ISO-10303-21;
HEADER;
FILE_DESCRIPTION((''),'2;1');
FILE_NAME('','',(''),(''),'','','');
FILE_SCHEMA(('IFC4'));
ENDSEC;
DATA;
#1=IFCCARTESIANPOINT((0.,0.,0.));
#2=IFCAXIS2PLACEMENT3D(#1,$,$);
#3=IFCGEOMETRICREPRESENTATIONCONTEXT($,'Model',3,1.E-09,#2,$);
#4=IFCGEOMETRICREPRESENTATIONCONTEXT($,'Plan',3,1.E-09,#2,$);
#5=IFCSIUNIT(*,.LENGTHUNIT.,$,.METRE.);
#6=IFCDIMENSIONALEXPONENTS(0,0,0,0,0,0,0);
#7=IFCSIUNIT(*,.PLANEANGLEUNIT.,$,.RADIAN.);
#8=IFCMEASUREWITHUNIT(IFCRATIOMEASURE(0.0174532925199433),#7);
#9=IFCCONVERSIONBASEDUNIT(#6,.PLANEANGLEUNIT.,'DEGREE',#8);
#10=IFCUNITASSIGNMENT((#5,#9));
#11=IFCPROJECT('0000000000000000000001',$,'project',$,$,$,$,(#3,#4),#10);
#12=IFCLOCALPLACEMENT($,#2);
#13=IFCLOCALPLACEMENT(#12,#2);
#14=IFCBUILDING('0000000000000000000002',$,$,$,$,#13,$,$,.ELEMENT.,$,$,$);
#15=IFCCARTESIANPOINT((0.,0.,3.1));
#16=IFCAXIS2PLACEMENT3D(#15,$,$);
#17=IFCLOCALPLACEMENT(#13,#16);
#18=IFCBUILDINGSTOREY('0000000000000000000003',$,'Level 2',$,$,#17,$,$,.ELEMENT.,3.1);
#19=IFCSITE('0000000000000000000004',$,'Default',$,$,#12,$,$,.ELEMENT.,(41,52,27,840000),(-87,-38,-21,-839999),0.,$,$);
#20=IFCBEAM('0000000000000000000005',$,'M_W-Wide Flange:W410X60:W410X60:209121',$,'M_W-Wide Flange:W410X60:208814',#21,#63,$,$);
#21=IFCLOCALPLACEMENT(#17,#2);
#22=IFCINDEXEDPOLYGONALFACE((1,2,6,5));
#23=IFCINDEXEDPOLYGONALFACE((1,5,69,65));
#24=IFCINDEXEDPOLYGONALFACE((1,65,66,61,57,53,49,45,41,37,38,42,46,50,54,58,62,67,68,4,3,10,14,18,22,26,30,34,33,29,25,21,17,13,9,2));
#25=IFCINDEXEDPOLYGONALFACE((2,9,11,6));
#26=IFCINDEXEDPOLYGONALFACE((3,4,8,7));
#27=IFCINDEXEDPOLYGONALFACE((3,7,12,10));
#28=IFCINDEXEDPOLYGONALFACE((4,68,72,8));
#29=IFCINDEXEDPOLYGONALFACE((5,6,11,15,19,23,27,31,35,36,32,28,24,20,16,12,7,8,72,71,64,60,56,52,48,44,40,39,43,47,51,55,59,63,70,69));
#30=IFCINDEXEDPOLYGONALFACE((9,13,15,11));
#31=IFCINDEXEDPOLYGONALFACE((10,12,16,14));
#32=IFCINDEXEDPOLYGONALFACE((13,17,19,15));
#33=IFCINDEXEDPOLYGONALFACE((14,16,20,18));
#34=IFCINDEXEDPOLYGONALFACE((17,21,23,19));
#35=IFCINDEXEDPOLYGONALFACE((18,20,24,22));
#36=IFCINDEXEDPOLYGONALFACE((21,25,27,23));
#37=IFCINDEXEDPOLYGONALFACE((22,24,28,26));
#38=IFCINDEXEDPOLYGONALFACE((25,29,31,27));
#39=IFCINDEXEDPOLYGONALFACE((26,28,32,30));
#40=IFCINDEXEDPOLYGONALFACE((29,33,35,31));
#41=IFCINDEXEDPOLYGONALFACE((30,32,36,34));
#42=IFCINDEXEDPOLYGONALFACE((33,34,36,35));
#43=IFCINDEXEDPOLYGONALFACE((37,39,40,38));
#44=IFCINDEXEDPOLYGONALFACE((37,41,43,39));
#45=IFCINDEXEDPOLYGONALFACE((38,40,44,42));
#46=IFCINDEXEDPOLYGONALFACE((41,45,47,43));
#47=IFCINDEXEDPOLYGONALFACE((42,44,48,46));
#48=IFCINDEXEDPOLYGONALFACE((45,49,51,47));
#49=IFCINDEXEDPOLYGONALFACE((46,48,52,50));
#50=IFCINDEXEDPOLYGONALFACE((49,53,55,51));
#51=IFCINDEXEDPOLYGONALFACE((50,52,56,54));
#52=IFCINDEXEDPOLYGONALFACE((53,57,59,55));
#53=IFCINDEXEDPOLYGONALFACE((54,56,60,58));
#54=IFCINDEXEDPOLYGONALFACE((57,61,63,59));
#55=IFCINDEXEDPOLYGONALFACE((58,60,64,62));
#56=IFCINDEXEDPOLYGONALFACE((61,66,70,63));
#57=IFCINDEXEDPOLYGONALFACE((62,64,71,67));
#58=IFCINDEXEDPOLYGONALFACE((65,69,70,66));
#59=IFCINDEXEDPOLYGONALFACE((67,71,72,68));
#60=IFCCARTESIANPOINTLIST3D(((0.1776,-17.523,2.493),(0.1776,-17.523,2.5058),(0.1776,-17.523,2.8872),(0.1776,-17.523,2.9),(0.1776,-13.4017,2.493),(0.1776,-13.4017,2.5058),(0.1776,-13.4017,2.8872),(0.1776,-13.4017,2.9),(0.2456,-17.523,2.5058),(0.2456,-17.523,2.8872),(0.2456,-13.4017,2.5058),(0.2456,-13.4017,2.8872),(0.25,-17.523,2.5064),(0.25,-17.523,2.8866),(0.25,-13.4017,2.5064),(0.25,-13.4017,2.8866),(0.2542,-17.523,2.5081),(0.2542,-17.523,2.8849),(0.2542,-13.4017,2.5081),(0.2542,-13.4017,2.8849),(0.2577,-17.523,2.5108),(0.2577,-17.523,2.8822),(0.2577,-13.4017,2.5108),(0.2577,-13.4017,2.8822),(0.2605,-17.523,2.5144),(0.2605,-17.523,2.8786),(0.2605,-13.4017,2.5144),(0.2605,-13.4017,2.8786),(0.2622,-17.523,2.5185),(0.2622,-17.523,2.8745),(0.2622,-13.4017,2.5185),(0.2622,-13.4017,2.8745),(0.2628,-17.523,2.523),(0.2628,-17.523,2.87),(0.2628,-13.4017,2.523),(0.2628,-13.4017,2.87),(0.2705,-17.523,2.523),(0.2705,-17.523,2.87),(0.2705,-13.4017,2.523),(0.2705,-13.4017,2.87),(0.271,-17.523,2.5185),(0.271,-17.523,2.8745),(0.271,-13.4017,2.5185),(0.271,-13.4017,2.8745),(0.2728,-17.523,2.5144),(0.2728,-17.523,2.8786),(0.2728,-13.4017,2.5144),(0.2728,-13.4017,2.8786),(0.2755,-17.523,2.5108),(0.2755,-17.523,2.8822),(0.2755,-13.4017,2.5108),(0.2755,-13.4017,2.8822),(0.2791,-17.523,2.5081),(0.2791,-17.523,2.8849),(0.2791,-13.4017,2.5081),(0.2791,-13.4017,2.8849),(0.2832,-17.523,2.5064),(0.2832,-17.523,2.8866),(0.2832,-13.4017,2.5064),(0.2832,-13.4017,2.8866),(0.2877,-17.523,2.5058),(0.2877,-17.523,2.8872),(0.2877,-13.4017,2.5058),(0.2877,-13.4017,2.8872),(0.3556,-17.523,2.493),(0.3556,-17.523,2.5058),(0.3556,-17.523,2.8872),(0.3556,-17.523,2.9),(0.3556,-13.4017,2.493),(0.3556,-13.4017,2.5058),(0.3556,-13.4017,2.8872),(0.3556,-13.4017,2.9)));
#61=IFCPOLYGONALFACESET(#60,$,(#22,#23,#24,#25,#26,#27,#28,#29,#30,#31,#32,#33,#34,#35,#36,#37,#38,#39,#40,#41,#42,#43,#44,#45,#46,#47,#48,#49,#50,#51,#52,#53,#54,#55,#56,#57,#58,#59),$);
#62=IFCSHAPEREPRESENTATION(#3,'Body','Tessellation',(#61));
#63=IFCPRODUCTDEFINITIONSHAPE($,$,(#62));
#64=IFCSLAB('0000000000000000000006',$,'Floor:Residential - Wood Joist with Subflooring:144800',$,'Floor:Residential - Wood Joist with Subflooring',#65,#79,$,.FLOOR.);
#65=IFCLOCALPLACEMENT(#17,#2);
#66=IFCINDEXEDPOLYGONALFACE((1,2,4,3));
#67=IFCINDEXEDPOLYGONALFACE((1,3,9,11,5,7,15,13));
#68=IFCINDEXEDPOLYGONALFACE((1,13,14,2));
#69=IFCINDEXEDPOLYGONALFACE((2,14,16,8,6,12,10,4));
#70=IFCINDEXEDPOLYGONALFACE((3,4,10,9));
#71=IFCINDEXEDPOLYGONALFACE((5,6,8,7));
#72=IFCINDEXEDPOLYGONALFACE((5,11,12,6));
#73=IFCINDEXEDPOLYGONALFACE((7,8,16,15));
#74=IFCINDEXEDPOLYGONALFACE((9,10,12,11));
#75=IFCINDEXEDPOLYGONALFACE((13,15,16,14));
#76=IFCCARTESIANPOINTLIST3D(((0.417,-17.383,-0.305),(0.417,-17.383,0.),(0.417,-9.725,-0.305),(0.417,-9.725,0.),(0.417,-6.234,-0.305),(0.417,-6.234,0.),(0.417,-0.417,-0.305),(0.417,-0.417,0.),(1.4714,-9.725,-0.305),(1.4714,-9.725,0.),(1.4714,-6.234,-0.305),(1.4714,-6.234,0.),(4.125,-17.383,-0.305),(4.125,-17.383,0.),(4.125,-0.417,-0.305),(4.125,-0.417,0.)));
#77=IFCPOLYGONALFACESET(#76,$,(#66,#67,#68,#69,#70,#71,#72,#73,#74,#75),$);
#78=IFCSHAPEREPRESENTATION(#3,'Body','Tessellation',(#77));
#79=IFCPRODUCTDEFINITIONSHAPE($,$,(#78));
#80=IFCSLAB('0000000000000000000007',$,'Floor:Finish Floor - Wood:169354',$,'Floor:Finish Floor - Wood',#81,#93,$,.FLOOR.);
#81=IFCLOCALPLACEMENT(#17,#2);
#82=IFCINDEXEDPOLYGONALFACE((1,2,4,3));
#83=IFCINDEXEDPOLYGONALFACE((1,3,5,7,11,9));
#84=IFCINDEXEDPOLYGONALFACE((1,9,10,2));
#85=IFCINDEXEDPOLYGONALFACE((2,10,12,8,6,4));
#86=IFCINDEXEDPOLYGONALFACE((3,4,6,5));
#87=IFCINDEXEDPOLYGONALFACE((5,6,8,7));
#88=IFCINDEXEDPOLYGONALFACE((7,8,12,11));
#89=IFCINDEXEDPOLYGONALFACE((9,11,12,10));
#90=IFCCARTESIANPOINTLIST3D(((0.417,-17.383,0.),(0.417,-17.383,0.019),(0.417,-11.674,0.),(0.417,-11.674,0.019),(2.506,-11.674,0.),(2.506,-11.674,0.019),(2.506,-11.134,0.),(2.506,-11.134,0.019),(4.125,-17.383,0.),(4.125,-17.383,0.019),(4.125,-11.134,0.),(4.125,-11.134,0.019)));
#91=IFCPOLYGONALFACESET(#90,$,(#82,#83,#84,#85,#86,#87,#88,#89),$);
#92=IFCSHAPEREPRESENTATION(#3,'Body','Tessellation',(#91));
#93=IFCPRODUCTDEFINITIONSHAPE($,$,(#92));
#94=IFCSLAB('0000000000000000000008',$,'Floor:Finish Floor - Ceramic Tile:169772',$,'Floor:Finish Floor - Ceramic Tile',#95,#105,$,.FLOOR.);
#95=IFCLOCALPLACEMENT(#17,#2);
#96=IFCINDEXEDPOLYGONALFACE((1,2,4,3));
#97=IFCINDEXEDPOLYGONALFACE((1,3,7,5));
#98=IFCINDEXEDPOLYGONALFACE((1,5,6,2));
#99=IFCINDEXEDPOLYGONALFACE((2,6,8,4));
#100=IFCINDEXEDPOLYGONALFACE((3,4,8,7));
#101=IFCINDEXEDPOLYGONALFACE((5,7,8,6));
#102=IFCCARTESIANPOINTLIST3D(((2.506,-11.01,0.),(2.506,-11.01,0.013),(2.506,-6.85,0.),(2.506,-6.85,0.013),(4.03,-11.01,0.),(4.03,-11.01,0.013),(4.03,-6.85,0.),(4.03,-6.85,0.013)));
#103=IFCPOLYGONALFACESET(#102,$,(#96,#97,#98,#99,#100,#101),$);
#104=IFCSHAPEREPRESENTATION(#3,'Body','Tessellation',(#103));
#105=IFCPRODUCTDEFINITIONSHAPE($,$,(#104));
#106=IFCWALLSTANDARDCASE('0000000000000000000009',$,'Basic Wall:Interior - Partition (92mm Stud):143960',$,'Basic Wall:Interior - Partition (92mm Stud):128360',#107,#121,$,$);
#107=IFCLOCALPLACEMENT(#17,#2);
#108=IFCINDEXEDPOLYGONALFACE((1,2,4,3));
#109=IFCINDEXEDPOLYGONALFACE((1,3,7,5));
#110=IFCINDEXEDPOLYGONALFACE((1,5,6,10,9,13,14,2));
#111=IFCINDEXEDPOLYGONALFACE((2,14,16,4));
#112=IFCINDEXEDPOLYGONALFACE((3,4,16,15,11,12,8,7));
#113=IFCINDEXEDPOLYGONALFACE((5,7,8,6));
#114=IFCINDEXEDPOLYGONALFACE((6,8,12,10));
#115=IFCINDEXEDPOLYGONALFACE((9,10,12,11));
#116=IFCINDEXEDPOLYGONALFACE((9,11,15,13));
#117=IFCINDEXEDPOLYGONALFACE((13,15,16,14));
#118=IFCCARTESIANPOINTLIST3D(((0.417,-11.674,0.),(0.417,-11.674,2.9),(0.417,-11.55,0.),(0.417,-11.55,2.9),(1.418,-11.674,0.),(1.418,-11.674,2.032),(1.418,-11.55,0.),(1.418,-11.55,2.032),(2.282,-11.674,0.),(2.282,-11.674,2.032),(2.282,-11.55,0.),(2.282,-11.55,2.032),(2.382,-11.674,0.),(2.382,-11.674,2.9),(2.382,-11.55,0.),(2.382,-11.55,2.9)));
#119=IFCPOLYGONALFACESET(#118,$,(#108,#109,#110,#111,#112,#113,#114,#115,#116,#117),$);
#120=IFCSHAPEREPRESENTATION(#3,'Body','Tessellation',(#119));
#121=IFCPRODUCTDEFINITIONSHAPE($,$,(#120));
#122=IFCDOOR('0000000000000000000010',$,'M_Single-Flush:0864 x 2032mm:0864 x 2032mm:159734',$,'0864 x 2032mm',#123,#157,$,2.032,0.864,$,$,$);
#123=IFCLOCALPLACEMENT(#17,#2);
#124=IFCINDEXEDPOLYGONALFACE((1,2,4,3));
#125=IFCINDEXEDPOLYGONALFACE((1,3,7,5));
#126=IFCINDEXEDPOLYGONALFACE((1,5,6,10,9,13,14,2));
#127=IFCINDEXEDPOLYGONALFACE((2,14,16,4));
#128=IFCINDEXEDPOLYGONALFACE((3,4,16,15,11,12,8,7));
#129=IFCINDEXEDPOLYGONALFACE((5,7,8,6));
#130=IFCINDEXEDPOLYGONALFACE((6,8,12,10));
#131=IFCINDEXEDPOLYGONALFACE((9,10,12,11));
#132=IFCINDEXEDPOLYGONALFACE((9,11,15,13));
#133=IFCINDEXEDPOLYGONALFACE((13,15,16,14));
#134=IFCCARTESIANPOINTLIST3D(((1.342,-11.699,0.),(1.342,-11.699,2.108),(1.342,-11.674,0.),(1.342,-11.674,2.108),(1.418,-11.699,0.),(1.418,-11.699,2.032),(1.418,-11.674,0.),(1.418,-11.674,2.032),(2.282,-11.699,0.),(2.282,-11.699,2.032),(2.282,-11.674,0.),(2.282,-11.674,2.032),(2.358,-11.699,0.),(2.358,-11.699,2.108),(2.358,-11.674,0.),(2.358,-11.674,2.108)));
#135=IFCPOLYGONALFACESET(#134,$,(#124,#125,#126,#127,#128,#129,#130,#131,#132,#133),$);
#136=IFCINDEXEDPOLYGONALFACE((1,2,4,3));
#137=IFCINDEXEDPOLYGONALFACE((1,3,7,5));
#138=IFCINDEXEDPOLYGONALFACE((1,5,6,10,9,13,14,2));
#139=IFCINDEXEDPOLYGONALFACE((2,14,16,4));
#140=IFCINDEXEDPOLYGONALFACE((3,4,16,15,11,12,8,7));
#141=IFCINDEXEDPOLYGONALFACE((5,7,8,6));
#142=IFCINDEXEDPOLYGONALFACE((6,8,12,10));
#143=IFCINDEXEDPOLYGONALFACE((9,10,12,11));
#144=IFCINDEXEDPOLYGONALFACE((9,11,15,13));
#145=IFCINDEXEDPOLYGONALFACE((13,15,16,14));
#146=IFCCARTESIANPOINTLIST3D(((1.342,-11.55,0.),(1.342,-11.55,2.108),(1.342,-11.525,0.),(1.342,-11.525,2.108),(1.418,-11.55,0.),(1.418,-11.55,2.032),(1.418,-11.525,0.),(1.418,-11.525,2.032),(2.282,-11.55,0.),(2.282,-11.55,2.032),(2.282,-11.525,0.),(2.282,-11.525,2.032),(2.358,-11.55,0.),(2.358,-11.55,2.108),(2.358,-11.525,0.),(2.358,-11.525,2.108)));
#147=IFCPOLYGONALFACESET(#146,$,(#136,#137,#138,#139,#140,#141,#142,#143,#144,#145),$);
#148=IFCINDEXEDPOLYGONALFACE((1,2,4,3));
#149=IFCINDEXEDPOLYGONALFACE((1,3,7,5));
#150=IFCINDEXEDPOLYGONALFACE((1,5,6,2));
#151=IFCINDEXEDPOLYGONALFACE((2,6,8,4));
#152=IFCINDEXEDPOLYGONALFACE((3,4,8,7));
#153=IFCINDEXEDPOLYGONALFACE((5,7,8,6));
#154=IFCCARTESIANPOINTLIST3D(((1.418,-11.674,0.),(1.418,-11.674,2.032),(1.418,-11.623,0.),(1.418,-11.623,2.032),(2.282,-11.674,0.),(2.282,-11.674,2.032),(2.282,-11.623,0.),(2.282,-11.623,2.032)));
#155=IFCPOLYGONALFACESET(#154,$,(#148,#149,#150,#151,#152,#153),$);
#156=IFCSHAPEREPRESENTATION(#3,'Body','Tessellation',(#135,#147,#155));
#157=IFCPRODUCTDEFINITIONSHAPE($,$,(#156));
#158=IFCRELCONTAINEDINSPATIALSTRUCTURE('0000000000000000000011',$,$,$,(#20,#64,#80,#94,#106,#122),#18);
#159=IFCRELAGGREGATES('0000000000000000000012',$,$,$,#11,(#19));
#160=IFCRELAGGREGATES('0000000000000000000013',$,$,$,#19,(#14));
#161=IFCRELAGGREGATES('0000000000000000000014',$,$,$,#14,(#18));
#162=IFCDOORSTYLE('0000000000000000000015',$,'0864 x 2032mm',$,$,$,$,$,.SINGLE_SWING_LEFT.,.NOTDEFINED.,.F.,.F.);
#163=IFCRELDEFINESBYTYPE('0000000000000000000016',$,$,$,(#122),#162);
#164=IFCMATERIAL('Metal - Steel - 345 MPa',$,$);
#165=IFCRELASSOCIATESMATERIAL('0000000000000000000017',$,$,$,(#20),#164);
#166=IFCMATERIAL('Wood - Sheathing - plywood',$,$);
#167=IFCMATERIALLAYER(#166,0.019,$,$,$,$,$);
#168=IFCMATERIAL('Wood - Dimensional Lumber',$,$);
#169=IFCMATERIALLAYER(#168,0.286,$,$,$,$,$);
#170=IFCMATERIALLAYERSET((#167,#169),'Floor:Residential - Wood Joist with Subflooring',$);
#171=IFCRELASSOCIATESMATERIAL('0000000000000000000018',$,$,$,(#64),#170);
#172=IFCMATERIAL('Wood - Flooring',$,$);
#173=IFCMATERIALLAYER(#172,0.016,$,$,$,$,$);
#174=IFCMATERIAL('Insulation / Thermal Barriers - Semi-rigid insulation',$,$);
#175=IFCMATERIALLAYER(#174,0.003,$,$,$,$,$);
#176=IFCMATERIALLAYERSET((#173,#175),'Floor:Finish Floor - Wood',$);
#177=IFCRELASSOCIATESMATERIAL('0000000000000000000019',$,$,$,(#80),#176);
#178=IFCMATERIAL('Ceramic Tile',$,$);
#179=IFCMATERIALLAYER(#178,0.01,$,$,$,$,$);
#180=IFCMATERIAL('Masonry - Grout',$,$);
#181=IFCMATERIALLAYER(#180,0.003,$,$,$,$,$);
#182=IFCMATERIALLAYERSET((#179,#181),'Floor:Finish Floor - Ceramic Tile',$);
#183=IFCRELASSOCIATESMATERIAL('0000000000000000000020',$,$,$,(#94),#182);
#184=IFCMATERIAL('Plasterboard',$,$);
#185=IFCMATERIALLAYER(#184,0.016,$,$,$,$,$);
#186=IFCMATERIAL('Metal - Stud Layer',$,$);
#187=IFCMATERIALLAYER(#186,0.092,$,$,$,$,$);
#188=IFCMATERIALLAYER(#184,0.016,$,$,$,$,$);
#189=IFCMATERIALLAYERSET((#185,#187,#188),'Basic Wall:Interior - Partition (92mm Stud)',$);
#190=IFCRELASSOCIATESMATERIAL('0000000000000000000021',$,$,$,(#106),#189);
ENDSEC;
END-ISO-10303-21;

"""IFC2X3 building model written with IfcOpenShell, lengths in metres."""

from ifc_helpers import new_model, entity, si_unit, converted_unit, frame, frame_2d, origin, origin_2d_with_axis, place, context, project, spatial, polyline, circle_curve, parameter, trimmed, segment, composite_curve, rectangle, outline, extrude, source, transform, mapped, material, layer, layer_set, layer_usage, type_object, type_shapes, element, fill, save


model = new_model("IFC2X3")

# Units and contexts
model_context = context("Model", 3, precision=1e-09, world=origin())
plan_context = context("Plan", 3, precision=1e-09, world=origin())
ifc_project = project(units=[si_unit("LENGTHUNIT", "METRE"), converted_unit("PLANEANGLEUNIT", "DEGREE", entity("IfcRatioMeasure", 0.0174532925199433), si_unit("PLANEANGLEUNIT", "RADIAN"), dimensions=[0, 0, 0, 0, 0, 0, 0])], contexts=[model_context, plan_context])

# Site, building, storey
site_placement = place(None, origin())
site = spatial("IfcSite", under=ifc_project, at=site_placement, Name="Default", CompositionType="ELEMENT", RefLatitude=(41, 52, 27, 840000), RefLongitude=(-87, -38, -21, -839999), RefElevation=0.0)
building_placement = place(site_placement, origin())
building = spatial("IfcBuilding", under=site, at=building_placement, CompositionType="ELEMENT")
storey_placement = place(building_placement, frame((0.0, 0.0, 3.1)))
storey = spatial("IfcBuildingStorey", under=building, at=storey_placement, Name="Level 2", CompositionType="ELEMENT", Elevation=3.1)

# Beam
ifc_material_1 = material(Name="Metal - Steel - 345 MPa")
beam_placement = place(storey_placement, frame((0.2666, -13.4017, 2.9), z_axis=(0.0, 0.0, 1.0), x_axis=(-1.0, 0.0, 0.0)))
element("IfcBeam", 1, at=beam_placement, inside=storey, material=ifc_material_1, Name="M_W-Wide Flange:W410X60:W410X60:209121", ObjectType="M_W-Wide Flange:W410X60:208814", context=model_context, shape_type="SweptSolid", body=[
    extrude(outline(composite_curve([segment(polyline([(0.1907, -0.089), (0.2035, -0.089)]), True, "CONTINUOUS"), segment(polyline([(0.2035, -0.089), (0.2035, 0.089)]), True, "CONTINUOUS"), segment(polyline([(0.2035, 0.089), (0.1907, 0.089)]), True, "CONTINUOUS"), segment(polyline([(0.1907, 0.089), (0.1907, 0.021)]), True, "CONTINUOUS"), segment(trimmed(circle_curve(frame_2d((0.1735, 0.021), x_axis=(1.0, 0.0)), 0.0172), [parameter(270.0)], [parameter(360.0)], True, "PARAMETER"), False, "CONTINUOUS"), segment(polyline([(0.1735, 0.0038), (-0.1735, 0.0038)]), True, "CONTINUOUS"), segment(trimmed(circle_curve(frame_2d((-0.1735, 0.021), x_axis=(0.0, -1.0)), 0.0172), [parameter(270.0)], [parameter(360.0)], True, "PARAMETER"), False, "CONTINUOUS"), segment(polyline([(-0.1907, 0.021), (-0.1907, 0.089)]), True, "CONTINUOUS"), segment(polyline([(-0.1907, 0.089), (-0.2035, 0.089)]), True, "CONTINUOUS"), segment(polyline([(-0.2035, 0.089), (-0.2035, -0.089)]), True, "CONTINUOUS"), segment(polyline([(-0.2035, -0.089), (-0.1907, -0.089)]), True, "CONTINUOUS"), segment(polyline([(-0.1907, -0.089), (-0.1907, -0.0211)]), True, "CONTINUOUS"), segment(trimmed(circle_curve(frame_2d((-0.1735, -0.0211), x_axis=(-1.0, 0.0)), 0.0172), [parameter(270.0)], [parameter(0.0)], True, "PARAMETER"), False, "CONTINUOUS"), segment(polyline([(-0.1735, -0.0039), (0.1735, -0.0039)]), True, "CONTINUOUS"), segment(trimmed(circle_curve(frame_2d((0.1735, -0.0211), x_axis=(0.0, 1.0)), 0.0172), [parameter(270.0)], [parameter(0.0)], True, "PARAMETER"), False, "CONTINUOUS"), segment(polyline([(0.1907, -0.0211), (0.1907, -0.089)]), True, "CONTINUOUS")], self_intersect=False)), frame((0.0, 4.1213, -0.2035), z_axis=(0.0, -1.0, 0.0), x_axis=(0.0, 0.0, -1.0)), (0.0, 0.0, 1.0), 4.1213),
])

# Slabs
ifc_material_2 = material(Name="Wood - Sheathing - plywood")
ifc_layer_1 = layer(ifc_material_2, 0.019)
ifc_material_3 = material(Name="Wood - Dimensional Lumber")
ifc_layer_2 = layer(ifc_material_3, 0.286)
ifc_layer_set_1 = layer_set([ifc_layer_1, ifc_layer_2], Name="Floor:Residential - Wood Joist with Subflooring")
ifc_layer_usage_1 = layer_usage(ifc_layer_set_1, "AXIS3", "POSITIVE", 0.0)
slab_1_placement = place(storey_placement, frame((0.417, -17.383, -0.305)))
element("IfcSlab", 2, at=slab_1_placement, inside=storey, material=ifc_layer_usage_1, Name="Floor:Residential - Wood Joist with Subflooring:144800", ObjectType="Floor:Residential - Wood Joist with Subflooring", PredefinedType="FLOOR", context=model_context, shape_type="SweptSolid", body=[
    extrude(outline(polyline([(-1.854, 8.483), (-1.854, -8.483), (1.854, -8.483), (1.854, -0.825), (0.7996, -0.825), (0.7996, 2.666), (1.854, 2.666), (1.854, 8.483), (-1.854, 8.483)])), frame((1.854, 8.483, 0.305), z_axis=(0.0, 0.0, -1.0), x_axis=(-1.0, 0.0, 0.0)), (0.0, 0.0, 1.0), 0.305),
])
ifc_material_4 = material(Name="Wood - Flooring")
ifc_layer_3 = layer(ifc_material_4, 0.016)
ifc_material_5 = material(Name="Insulation / Thermal Barriers - Semi-rigid insulation")
ifc_layer_4 = layer(ifc_material_5, 0.003)
ifc_layer_set_2 = layer_set([ifc_layer_3, ifc_layer_4], Name="Floor:Finish Floor - Wood")
ifc_layer_usage_2 = layer_usage(ifc_layer_set_2, "AXIS3", "POSITIVE", 0.0)
slab_2_placement = place(storey_placement, frame((0.417, -17.383, 0.0)))
element("IfcSlab", 3, at=slab_2_placement, inside=storey, material=ifc_layer_usage_2, Name="Floor:Finish Floor - Wood:169354", ObjectType="Floor:Finish Floor - Wood", PredefinedType="FLOOR", context=model_context, shape_type="SweptSolid", body=[
    extrude(outline(polyline([(-1.854, -3.1245), (1.854, -3.1245), (1.854, 2.5845), (-0.235, 2.5845), (-0.235, 3.1245), (-1.854, 3.1245), (-1.854, -3.1245)])), frame((1.854, 3.1245, 0.019), z_axis=(0.0, 0.0, -1.0), x_axis=(-1.0, 0.0, 0.0)), (0.0, 0.0, 1.0), 0.019),
])
ifc_material_6 = material(Name="Ceramic Tile")
ifc_layer_5 = layer(ifc_material_6, 0.01)
ifc_material_7 = material(Name="Masonry - Grout")
ifc_layer_6 = layer(ifc_material_7, 0.003)
ifc_layer_set_3 = layer_set([ifc_layer_5, ifc_layer_6], Name="Floor:Finish Floor - Ceramic Tile")
ifc_layer_usage_3 = layer_usage(ifc_layer_set_3, "AXIS3", "POSITIVE", 0.0)
slab_3_placement = place(storey_placement, frame((2.506, -11.01, 0.0)))
element("IfcSlab", 4, at=slab_3_placement, inside=storey, material=ifc_layer_usage_3, Name="Floor:Finish Floor - Ceramic Tile:169772", ObjectType="Floor:Finish Floor - Ceramic Tile", PredefinedType="FLOOR", context=model_context, shape_type="SweptSolid", body=[
    extrude(rectangle(XDim=4.16, YDim=1.524, at=frame_2d((0.0, 0.0), x_axis=(0.0, -1.0))), frame((0.762, 2.08, 0.013), z_axis=(0.0, 0.0, -1.0), x_axis=(-1.0, 0.0, 0.0)), (0.0, 0.0, 1.0), 0.013),
])

# Shared definitions
ifc_material_8 = material(Name="Metal - Stud Layer")
ifc_material_9 = material(Name="Plasterboard")

# Wall, opening, door
ifc_layer_7 = layer(ifc_material_9, 0.016)
ifc_layer_8 = layer(ifc_material_8, 0.092)
ifc_layer_9 = layer(ifc_material_9, 0.016)
ifc_layer_set_4 = layer_set([ifc_layer_7, ifc_layer_8, ifc_layer_9], Name="Basic Wall:Interior - Partition (92mm Stud)")
ifc_layer_usage_4 = layer_usage(ifc_layer_set_4, "AXIS2", "NEGATIVE", 0.062)
wall_1_placement = place(storey_placement, frame((2.382, -11.612, 0.0), z_axis=(0.0, 0.0, 1.0), x_axis=(-1.0, 0.0, 0.0)))
wall_1 = element("IfcWallStandardCase", 5, at=wall_1_placement, inside=storey, material=ifc_layer_usage_4, Name="Basic Wall:Interior - Partition (92mm Stud):143960", ObjectType="Basic Wall:Interior - Partition (92mm Stud):128360", context=model_context, shape_type="SweptSolid", body=[
    extrude(rectangle(XDim=1.965, YDim=0.124, at=frame_2d((0.9825, 0.0), x_axis=(-1.0, 0.0))), origin(), (0.0, 0.0, 1.0), 2.9),
])
opening_1_placement = place(wall_1_placement, frame((0.1, -0.062, 0.0)))
opening_1 = element("IfcOpeningElement", 6, at=opening_1_placement, cuts=wall_1, ObjectType="Opening", context=model_context, shape_type="SweptSolid", body=[
    extrude(rectangle(XDim=0.864, YDim=2.032, at=frame_2d((1.016, 0.432), x_axis=(0.0, -1.0))), frame((0.0, 0.0, 0.0), z_axis=(0.0, 1.0, 0.0), x_axis=(0.0, 0.0, 1.0)), (0.0, 0.0, 1.0), 0.124),
])
door_style = type_object("IfcDoorStyle", Name="0864 x 2032mm", ConstructionType="NOTDEFINED", OperationType="SINGLE_SWING_LEFT", ParameterTakesPrecedence=False, Sizeable=False)
shared_shape_1 = source(origin(), model_context, "Body", "SweptSolid", [
    extrude(outline(polyline([(-0.508, -1.073), (0.508, -1.073), (0.508, 1.035), (0.432, 1.035), (0.432, -0.997), (-0.432, -0.997), (-0.432, 1.035), (-0.508, 1.035), (-0.508, -1.073)])), frame((0.432, 0.149, 1.035), z_axis=(0.0, -1.0, 0.0), x_axis=(-1.0, 0.0, 0.0)), (0.0, 0.0, 1.0), 0.025),
    extrude(outline(polyline([(-1.073, -0.508), (1.035, -0.508), (1.035, -0.432), (-0.997, -0.432), (-0.997, 0.432), (1.035, 0.432), (1.035, 0.508), (-1.073, 0.508), (-1.073, -0.508)])), frame((0.432, 0.0, 1.035), z_axis=(0.0, -1.0, 0.0), x_axis=(0.0, 0.0, -1.0)), (0.0, 0.0, 1.0), 0.025),
    extrude(rectangle(XDim=0.864, YDim=0.051, at=origin_2d_with_axis()), frame((0.432, 0.0985, 0.0)), (0.0, 0.0, 1.0), 2.032),
])
type_shapes(door_style, [shared_shape_1])
door_placement = place(opening_1_placement, origin())
door = element("IfcDoor", 7, at=door_placement, inside=storey, type_object=door_style, Name="M_Single-Flush:0864 x 2032mm:0864 x 2032mm:159734", ObjectType="0864 x 2032mm", OverallHeight=2.032, OverallWidth=0.864, context=model_context, shape_type="MappedRepresentation", body=[
    mapped(shared_shape_1, transform((0.0, 0.0, 0.0), scale=1.0)),
])
fill(opening_1, door)

save(model, "model.ifc")
